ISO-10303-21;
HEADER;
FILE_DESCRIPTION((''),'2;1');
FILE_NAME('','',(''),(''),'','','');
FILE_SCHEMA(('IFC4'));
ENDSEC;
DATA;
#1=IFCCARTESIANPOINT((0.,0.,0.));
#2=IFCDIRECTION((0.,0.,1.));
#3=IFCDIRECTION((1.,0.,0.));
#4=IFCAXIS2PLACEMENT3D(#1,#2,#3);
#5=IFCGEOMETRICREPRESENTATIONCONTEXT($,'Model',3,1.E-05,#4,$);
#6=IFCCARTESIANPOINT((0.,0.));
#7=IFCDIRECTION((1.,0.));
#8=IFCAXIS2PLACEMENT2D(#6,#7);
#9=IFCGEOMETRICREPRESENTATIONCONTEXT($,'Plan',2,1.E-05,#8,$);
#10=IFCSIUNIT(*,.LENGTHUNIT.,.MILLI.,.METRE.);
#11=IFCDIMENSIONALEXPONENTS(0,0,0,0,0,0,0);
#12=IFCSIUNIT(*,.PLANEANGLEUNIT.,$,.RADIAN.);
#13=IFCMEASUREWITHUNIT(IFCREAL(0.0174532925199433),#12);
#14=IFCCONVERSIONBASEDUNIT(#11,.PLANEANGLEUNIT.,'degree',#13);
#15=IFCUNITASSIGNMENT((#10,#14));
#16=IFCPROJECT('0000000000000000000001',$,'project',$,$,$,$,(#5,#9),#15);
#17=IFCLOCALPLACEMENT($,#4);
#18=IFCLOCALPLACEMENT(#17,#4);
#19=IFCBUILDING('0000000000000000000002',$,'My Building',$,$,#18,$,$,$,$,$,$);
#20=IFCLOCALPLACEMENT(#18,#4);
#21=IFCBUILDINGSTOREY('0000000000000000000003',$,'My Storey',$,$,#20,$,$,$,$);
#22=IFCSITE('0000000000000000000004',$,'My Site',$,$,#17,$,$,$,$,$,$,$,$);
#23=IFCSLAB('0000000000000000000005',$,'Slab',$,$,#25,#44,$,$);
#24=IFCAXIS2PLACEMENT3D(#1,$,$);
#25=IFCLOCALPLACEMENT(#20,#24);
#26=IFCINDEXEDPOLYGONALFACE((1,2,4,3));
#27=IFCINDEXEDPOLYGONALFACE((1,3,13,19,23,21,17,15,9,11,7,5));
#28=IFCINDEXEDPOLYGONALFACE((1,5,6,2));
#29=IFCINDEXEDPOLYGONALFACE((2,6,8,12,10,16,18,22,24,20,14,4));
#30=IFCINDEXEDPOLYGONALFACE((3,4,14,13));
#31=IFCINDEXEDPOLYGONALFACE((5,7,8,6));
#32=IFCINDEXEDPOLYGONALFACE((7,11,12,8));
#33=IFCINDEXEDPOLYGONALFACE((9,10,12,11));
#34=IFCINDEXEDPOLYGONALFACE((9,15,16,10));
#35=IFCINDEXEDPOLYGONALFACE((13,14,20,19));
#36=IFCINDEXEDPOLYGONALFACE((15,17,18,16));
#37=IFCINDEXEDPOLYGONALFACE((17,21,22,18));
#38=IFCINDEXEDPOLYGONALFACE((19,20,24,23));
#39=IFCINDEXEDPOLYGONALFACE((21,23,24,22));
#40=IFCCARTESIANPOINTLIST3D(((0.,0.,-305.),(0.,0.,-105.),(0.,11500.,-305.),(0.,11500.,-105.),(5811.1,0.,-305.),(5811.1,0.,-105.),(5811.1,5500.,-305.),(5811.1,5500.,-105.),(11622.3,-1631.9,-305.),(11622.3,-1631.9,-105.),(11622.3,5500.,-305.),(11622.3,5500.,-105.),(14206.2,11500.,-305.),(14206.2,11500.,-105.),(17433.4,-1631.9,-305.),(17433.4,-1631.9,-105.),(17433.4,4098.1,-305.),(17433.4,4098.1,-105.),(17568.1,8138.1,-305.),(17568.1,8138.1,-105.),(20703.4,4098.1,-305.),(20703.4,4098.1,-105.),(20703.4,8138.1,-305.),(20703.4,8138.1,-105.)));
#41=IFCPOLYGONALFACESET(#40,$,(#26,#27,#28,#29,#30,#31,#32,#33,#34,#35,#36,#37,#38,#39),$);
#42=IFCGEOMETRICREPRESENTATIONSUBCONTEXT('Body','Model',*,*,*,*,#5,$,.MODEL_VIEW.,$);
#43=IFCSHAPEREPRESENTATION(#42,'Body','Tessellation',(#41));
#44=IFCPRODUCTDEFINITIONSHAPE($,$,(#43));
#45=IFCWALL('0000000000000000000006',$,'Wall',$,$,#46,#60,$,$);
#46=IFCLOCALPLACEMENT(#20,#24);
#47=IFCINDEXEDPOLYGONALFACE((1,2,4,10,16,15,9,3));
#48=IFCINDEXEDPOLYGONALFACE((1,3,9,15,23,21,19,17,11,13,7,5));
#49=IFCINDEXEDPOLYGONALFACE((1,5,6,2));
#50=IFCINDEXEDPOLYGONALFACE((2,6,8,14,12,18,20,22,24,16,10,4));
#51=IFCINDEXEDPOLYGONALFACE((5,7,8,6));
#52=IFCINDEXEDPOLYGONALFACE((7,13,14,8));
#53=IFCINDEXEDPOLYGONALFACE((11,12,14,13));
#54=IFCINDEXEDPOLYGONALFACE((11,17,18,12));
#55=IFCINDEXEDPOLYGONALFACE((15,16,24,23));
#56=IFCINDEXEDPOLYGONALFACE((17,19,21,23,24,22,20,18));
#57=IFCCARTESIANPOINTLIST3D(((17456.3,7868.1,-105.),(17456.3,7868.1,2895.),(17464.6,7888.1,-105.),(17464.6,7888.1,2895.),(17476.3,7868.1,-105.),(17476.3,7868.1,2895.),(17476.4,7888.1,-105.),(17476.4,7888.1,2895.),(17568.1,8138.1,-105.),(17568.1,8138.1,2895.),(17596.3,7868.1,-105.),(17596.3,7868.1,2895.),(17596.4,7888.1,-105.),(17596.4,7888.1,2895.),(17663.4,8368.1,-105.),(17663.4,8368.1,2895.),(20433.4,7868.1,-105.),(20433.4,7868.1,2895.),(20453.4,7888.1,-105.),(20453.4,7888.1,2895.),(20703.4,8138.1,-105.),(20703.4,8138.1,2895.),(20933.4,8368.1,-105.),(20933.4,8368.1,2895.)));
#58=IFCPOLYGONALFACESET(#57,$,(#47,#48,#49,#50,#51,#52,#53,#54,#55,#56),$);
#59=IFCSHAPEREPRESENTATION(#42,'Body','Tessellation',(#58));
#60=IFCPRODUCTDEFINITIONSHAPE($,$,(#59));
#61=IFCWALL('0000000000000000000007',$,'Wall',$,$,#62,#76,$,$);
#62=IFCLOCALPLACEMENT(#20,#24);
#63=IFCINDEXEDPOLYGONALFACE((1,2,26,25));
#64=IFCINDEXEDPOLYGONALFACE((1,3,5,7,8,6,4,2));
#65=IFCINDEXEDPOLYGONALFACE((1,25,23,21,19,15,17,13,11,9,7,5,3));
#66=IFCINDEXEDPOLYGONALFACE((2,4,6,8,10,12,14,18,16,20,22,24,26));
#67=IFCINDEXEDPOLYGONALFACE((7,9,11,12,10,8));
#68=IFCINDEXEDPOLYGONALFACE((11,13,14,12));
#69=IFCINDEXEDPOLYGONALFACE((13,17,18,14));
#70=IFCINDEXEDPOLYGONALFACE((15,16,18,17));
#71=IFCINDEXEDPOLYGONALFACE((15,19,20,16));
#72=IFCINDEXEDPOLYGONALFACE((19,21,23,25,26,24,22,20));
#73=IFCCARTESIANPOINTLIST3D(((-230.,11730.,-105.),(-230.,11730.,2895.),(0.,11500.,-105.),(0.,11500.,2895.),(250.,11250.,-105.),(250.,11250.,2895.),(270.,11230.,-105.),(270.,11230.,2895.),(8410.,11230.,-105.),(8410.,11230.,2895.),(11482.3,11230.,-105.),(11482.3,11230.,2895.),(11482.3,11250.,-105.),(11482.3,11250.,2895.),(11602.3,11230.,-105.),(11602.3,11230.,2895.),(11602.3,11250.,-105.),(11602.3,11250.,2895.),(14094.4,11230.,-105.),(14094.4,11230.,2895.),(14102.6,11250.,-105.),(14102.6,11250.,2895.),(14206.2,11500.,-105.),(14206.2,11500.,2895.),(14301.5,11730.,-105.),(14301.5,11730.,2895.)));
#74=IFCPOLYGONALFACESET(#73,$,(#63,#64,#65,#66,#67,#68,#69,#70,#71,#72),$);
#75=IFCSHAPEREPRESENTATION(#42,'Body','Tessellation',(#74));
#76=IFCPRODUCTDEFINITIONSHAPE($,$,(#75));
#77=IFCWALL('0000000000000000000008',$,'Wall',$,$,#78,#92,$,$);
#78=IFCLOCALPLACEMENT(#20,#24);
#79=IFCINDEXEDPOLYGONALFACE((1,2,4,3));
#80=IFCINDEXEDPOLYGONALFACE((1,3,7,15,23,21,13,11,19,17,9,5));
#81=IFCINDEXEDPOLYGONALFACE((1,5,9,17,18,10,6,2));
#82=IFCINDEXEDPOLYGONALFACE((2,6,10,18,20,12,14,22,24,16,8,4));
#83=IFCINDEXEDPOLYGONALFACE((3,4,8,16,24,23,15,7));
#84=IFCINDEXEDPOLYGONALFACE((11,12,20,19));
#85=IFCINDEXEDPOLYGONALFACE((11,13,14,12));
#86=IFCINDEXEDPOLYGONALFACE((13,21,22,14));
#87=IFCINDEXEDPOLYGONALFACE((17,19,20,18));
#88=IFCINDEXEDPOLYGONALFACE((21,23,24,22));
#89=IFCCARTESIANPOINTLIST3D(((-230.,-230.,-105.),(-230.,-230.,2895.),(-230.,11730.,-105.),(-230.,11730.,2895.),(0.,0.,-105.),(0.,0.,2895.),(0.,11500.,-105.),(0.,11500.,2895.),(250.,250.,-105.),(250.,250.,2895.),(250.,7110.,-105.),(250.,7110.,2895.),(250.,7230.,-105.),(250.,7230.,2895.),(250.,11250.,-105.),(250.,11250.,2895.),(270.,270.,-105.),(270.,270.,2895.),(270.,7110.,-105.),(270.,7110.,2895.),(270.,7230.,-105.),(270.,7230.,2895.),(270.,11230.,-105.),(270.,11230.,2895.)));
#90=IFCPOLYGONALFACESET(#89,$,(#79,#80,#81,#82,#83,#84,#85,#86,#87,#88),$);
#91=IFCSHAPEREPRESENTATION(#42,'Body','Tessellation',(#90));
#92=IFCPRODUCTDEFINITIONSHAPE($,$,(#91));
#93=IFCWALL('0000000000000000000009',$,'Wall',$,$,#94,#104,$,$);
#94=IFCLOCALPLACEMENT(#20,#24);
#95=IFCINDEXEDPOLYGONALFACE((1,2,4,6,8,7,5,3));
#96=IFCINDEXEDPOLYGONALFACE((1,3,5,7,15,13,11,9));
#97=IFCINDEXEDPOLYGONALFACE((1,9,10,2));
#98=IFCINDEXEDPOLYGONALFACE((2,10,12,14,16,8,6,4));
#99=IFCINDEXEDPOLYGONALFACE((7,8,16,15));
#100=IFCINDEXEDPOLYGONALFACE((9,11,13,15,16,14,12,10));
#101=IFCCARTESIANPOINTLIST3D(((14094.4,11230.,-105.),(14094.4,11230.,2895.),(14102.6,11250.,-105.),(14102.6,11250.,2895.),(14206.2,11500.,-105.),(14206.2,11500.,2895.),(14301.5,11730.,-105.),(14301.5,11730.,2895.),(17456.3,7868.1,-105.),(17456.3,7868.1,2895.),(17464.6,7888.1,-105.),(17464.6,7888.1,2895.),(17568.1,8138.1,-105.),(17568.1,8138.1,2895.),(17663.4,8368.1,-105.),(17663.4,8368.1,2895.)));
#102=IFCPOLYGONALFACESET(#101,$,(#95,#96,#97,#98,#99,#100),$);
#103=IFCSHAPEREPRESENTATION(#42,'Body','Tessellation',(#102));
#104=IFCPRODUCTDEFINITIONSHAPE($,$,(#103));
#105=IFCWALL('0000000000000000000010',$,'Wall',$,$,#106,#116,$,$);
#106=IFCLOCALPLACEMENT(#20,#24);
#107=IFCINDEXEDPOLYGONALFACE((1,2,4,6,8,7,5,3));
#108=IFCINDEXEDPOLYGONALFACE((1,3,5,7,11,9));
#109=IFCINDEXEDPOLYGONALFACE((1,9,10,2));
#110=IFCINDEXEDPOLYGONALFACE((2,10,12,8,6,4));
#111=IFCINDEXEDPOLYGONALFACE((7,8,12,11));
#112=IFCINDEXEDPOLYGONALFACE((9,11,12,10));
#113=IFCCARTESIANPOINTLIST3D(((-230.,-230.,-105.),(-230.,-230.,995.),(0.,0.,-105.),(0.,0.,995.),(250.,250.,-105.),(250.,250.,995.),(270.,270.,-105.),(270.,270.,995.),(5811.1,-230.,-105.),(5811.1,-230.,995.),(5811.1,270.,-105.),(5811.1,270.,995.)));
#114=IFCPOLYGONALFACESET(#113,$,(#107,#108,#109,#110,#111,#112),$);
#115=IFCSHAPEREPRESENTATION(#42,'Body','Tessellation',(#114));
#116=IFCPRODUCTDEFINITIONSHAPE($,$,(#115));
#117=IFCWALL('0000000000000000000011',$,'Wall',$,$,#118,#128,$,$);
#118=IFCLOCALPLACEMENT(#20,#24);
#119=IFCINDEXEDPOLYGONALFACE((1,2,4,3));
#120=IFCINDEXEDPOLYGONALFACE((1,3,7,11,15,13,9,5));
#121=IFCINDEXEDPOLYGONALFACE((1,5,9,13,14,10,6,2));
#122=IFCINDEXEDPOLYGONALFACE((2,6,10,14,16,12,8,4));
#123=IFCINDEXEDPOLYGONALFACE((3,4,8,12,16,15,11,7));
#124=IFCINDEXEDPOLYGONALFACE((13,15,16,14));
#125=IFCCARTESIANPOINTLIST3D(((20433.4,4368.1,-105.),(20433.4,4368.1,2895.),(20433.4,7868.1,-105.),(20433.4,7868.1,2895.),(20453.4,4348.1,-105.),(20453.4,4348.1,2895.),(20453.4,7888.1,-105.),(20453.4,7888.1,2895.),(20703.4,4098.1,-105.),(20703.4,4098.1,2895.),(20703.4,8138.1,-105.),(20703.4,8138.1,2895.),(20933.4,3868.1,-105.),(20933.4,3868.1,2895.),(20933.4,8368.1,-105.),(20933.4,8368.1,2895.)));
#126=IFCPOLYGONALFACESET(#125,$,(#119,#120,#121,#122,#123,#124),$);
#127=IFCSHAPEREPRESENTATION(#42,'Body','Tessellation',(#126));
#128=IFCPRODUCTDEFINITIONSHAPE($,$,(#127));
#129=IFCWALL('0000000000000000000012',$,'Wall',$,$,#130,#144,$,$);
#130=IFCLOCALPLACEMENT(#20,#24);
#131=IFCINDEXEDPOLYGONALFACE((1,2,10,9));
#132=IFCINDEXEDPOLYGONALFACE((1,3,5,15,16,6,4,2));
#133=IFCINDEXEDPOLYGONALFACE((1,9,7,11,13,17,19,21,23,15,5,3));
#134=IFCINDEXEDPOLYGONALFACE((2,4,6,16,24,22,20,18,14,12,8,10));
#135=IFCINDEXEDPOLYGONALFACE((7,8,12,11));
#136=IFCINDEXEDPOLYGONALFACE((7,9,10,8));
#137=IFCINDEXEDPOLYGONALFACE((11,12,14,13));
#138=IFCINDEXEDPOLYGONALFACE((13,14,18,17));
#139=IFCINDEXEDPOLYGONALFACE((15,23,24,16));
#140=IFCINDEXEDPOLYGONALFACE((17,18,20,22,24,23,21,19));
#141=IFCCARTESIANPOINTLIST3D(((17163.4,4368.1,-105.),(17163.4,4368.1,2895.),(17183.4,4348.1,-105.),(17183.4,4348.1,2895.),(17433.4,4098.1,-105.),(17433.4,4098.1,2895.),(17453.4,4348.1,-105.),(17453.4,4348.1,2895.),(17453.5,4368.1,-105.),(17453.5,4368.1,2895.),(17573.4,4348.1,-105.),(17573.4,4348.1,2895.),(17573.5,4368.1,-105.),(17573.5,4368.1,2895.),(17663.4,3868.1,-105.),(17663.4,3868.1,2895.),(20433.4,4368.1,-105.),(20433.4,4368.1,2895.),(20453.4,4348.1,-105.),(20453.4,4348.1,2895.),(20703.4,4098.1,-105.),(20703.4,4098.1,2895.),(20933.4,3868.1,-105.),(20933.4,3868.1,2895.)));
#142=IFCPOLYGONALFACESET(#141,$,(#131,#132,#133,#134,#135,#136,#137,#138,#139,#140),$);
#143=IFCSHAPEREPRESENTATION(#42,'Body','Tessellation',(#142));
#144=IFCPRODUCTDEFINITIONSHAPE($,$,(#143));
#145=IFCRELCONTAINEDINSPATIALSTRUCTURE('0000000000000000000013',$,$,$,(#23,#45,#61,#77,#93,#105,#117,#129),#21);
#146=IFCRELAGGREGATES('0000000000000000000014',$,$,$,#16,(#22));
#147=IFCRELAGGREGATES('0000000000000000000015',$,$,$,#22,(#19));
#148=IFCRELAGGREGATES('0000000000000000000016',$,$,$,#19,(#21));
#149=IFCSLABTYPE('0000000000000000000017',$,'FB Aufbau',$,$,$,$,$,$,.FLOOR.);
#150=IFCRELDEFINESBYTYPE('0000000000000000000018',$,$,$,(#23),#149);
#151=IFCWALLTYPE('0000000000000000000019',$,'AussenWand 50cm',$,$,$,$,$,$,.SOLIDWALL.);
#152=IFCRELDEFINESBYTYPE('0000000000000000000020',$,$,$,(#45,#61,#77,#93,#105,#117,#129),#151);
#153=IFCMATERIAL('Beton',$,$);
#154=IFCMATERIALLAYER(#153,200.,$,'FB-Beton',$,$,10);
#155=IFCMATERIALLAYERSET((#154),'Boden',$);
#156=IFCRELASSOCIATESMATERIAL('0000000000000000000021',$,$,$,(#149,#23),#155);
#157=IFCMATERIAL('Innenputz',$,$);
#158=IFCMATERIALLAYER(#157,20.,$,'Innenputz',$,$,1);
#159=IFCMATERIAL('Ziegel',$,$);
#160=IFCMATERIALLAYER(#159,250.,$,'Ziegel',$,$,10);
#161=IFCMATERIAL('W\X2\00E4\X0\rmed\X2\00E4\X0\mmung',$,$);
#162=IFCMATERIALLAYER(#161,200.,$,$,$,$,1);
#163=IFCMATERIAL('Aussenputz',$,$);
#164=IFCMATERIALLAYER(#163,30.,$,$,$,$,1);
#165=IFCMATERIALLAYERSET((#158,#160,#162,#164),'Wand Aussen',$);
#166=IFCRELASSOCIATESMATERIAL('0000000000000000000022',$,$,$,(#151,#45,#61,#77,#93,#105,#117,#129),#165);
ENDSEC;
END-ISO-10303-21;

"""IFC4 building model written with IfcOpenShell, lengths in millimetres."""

from ifc_helpers import new_model, entity, si_unit, converted_unit, frame, origin_with_axes, origin_2d_with_axis, place, context, subcontext, project, spatial, line, indexed_curve, outline, extrude, material, layer, layer_set, layer_usage, type_object, element, save


model = new_model("IFC4")

# Units and contexts
model_context = context("Model", 3, precision=1e-05, world=origin_with_axes())
plan_context = context("Plan", 2, precision=1e-05, world=origin_2d_with_axis())
body_context = subcontext(model_context, "Body", "Model", "MODEL_VIEW")
ifc_project = project(units=[si_unit("LENGTHUNIT", "METRE", prefix="MILLI"), converted_unit("PLANEANGLEUNIT", "degree", entity("IfcReal", 0.0174532925199433), si_unit("PLANEANGLEUNIT", "RADIAN"), dimensions=[0, 0, 0, 0, 0, 0, 0])], contexts=[model_context, plan_context])

# Site, building, storey
site_placement = place(None, origin_with_axes())
site = spatial("IfcSite", under=ifc_project, at=site_placement, Name="My Site")
building_placement = place(site_placement, origin_with_axes())
building = spatial("IfcBuilding", under=site, at=building_placement, Name="My Building")
storey_placement = place(building_placement, origin_with_axes())
storey = spatial("IfcBuildingStorey", under=building, at=storey_placement, Name="My Storey")

# Slab
ifc_material_1 = material(Name="Beton")
ifc_layer_1 = layer(ifc_material_1, 200.0, Name="FB-Beton", Priority=10)
ifc_layer_set_1 = layer_set([ifc_layer_1], Name="Boden")
ifc_layer_usage_1 = layer_usage(ifc_layer_set_1, "AXIS3", "POSITIVE", 0.0)
slab_type = type_object("IfcSlabType", Name="FB Aufbau", PredefinedType="FLOOR", material=ifc_layer_set_1)
slab_placement = place(storey_placement, frame((0.0, 0.0, -305.0), z_axis=(0.0, 0.0, 1.0), x_axis=(1.0, 0.0, 0.0)))
element("IfcSlab", 1, at=slab_placement, inside=storey, type_object=slab_type, material=ifc_layer_usage_1, Name="Slab", context=body_context, shape_type="SweptSolid", body=[
    extrude(outline(indexed_curve([(5811.1, 5500.0), (5811.1, 0.0), (0.0, 0.0), (0.0, 11500.0), (14206.2, 11500.0), (17568.1, 8138.1), (20703.4, 8138.1), (20703.4, 4098.1), (17433.4, 4098.1), (17433.4, -1631.9), (11622.3, -1631.9), (11622.3, 5500.0), (5811.1, 5500.0)])), origin_with_axes(), (0.0, 0.0, 1.0), 200.0),
])

# Walls
ifc_material_2 = material(Name="Innenputz")
ifc_layer_2 = layer(ifc_material_2, 20.0, Name="Innenputz", Priority=1)
ifc_material_3 = material(Name="Ziegel")
ifc_layer_3 = layer(ifc_material_3, 250.0, Name="Ziegel", Priority=10)
ifc_material_4 = material(Name="Wärmedämmung")
ifc_layer_4 = layer(ifc_material_4, 200.0, Priority=1)
ifc_material_5 = material(Name="Aussenputz")
ifc_layer_5 = layer(ifc_material_5, 30.0, Priority=1)
ifc_layer_set_2 = layer_set([ifc_layer_2, ifc_layer_3, ifc_layer_4, ifc_layer_5], Name="Wand Aussen")
ifc_layer_usage_2 = layer_usage(ifc_layer_set_2, "AXIS2", "POSITIVE", 0.0)
wall_type_1 = type_object("IfcWallType", Name="AussenWand 50cm", PredefinedType="SOLIDWALL", material=ifc_layer_set_2)
wall_1_placement = place(storey_placement, frame((17456.3, 7868.1, -105.0), z_axis=(0.0, 0.0, 1.0), x_axis=(1.0, 0.0, 0.0)))
element("IfcWall", 2, at=wall_1_placement, inside=storey, type_object=wall_type_1, material=ifc_layer_usage_2, Name="Wall", context=body_context, shape_type="SweptSolid", body=[
    extrude(outline(indexed_curve([(0.0, 0.0), (8.3, 20.0), (111.8, 270.0), (207.1, 500.0), (3477.1, 500.0), (3247.1, 270.0), (2997.1, 20.0), (2977.1, 0.0), (140.0, 0.0), (140.1, 20.0), (20.1, 20.0), (20.0, 0.0)], segments=[line(1, 2, 3, 4, 5, 6, 7, 8, 9, 10, 11, 12, 1)])), origin_with_axes(), (0.0, 0.0, 1.0), 3000.0),
])
ifc_layer_usage_3 = layer_usage(ifc_layer_set_2, "AXIS2", "NEGATIVE", 0.0)
wall_2_placement = place(storey_placement, frame((14094.4, 11230.0, -105.0), z_axis=(0.0, 0.0, 1.0), x_axis=(-1.0, 0.0, 0.0)))
element("IfcWall", 3, at=wall_2_placement, inside=storey, type_object=wall_type_1, material=ifc_layer_usage_3, Name="Wall", context=body_context, shape_type="SweptSolid", body=[
    extrude(outline(indexed_curve([(-207.1, -500.0), (-111.8, -270.0), (-8.3, -20.0), (0.0, 0.0), (2492.1, 0.0), (2492.1, -20.0), (2612.1, -20.0), (2612.1, 0.0), (9804.4, 0.0), (9804.4, -20.0), (9684.4, -20.0), (9684.4, 0.0), (5804.4, 0.0), (5804.4, -20.0), (5684.4, -20.0), (5684.4, 0.0), (13824.4, 0.0), (13844.4, -20.0), (14094.4, -270.0), (14324.4, -500.0)], segments=[line(1, 2, 3, 4, 5, 6, 7, 8, 9, 10, 11, 12, 13, 14, 15, 16, 17, 18, 19, 20, 1)])), origin_with_axes(), (0.0, 0.0, 1.0), 3000.0),
])
ifc_layer_usage_4 = layer_usage(ifc_layer_set_2, "AXIS2", "NEGATIVE", 0.0, extent=0.0)
wall_3_placement = place(storey_placement, frame((270.0, 11230.0, -105.0), z_axis=(0.0, 0.0, 1.0), x_axis=(0.0, -1.0, 0.0)))
element("IfcWall", 4, at=wall_3_placement, inside=storey, type_object=wall_type_1, material=ifc_layer_usage_4, Name="Wall", context=body_context, shape_type="SweptSolid", body=[
    extrude(outline(indexed_curve([(-500.0, -500.0), (-270.0, -270.0), (-20.0, -20.0), (0.0, 0.0), (4000.0, 0.0), (4000.0, -20.0), (4120.0, -20.0), (4120.0, 0.0), (10960.0, 0.0), (10980.0, -20.0), (11230.0, -270.0), (11460.0, -500.0)], segments=[line(1, 2, 3, 4, 5, 6, 7, 8, 9, 10, 11, 12, 1)])), origin_with_axes(), (0.0, 0.0, 1.0), 3000.0),
])
ifc_layer_usage_5 = layer_usage(ifc_layer_set_2, "AXIS2", "NEGATIVE", 0.0)
wall_4_placement = place(storey_placement, frame((17456.3, 7868.1, -105.0), z_axis=(0.0, 0.0, 1.0), x_axis=(-0.707107, 0.707107, 0.0)))
element("IfcWall", 5, at=wall_4_placement, inside=storey, type_object=wall_type_1, material=ifc_layer_usage_5, Name="Wall", context=body_context, shape_type="SweptSolid", body=[
    extrude(outline(indexed_curve([(207.1, -500.0), (111.8, -270.0), (8.3, -20.0), (0.0, 0.0), (4754.5, 0.0), (4762.8, -20.0), (4866.3, -270.0), (4961.6, -500.0)], segments=[line(1, 2, 3, 4, 5, 6, 7, 8, 1)])), origin_with_axes(), (0.0, 0.0, 1.0), 3000.0),
])
ifc_layer_usage_6 = layer_usage(ifc_layer_set_2, "AXIS2", "NEGATIVE", 0.0)
wall_5_placement = place(storey_placement, frame((270.0, 270.0, -105.0), z_axis=(0.0, 0.0, 1.0), x_axis=(1.0, 0.0, 0.0)))
element("IfcWall", 6, at=wall_5_placement, inside=storey, type_object=wall_type_1, material=ifc_layer_usage_6, Name="Wall", context=body_context, shape_type="SweptSolid", body=[
    extrude(outline(indexed_curve([(-500.0, -500.0), (-270.0, -270.0), (-20.0, -20.0), (0.0, 0.0), (5541.1, 0.0), (5541.1, -500.0)], segments=[line(1, 2, 3, 4, 5, 6, 1)])), origin_with_axes(), (0.0, 0.0, 1.0), 1100.0),
])
ifc_layer_usage_7 = layer_usage(ifc_layer_set_2, "AXIS2", "POSITIVE", 0.0)
wall_6_placement = place(storey_placement, frame((20433.4, 7868.1, -105.0), z_axis=(0.0, 0.0, 1.0), x_axis=(0.0, -1.0, 0.0)))
element("IfcWall", 7, at=wall_6_placement, inside=storey, type_object=wall_type_1, material=ifc_layer_usage_7, Name="Wall", context=body_context, shape_type="SweptSolid", body=[
    extrude(outline(indexed_curve([(0.0, 0.0), (-20.0, 20.0), (-270.0, 270.0), (-500.0, 500.0), (4000.0, 500.0), (3770.0, 270.0), (3520.0, 20.0), (3500.0, 0.0)], segments=[line(1, 2, 3, 4, 5, 6, 7, 8, 1)])), origin_with_axes(), (0.0, 0.0, 1.0), 3000.0),
])
ifc_layer_usage_8 = layer_usage(ifc_layer_set_2, "AXIS2", "POSITIVE", 0.0)
wall_7_placement = place(storey_placement, frame((20433.4, 4368.1, -105.0), z_axis=(0.0, 0.0, 1.0), x_axis=(-1.0, 0.0, 0.0)))
element("IfcWall", 8, at=wall_7_placement, inside=storey, type_object=wall_type_1, material=ifc_layer_usage_8, Name="Wall", context=body_context, shape_type="SweptSolid", body=[
    extrude(outline(indexed_curve([(0.0, 0.0), (-20.0, 20.0), (-270.0, 270.0), (-500.0, 500.0), (2770.0, 500.0), (3000.0, 270.0), (3250.0, 20.0), (3270.0, 0.0), (2979.9, 0.0), (2980.0, 20.0), (2860.0, 20.0), (2859.9, 0.0)], segments=[line(1, 2, 3, 4, 5, 6, 7, 8, 9, 10, 11, 12, 1)])), origin_with_axes(), (0.0, 0.0, 1.0), 3000.0),
])

save(model, "model.ifc")
